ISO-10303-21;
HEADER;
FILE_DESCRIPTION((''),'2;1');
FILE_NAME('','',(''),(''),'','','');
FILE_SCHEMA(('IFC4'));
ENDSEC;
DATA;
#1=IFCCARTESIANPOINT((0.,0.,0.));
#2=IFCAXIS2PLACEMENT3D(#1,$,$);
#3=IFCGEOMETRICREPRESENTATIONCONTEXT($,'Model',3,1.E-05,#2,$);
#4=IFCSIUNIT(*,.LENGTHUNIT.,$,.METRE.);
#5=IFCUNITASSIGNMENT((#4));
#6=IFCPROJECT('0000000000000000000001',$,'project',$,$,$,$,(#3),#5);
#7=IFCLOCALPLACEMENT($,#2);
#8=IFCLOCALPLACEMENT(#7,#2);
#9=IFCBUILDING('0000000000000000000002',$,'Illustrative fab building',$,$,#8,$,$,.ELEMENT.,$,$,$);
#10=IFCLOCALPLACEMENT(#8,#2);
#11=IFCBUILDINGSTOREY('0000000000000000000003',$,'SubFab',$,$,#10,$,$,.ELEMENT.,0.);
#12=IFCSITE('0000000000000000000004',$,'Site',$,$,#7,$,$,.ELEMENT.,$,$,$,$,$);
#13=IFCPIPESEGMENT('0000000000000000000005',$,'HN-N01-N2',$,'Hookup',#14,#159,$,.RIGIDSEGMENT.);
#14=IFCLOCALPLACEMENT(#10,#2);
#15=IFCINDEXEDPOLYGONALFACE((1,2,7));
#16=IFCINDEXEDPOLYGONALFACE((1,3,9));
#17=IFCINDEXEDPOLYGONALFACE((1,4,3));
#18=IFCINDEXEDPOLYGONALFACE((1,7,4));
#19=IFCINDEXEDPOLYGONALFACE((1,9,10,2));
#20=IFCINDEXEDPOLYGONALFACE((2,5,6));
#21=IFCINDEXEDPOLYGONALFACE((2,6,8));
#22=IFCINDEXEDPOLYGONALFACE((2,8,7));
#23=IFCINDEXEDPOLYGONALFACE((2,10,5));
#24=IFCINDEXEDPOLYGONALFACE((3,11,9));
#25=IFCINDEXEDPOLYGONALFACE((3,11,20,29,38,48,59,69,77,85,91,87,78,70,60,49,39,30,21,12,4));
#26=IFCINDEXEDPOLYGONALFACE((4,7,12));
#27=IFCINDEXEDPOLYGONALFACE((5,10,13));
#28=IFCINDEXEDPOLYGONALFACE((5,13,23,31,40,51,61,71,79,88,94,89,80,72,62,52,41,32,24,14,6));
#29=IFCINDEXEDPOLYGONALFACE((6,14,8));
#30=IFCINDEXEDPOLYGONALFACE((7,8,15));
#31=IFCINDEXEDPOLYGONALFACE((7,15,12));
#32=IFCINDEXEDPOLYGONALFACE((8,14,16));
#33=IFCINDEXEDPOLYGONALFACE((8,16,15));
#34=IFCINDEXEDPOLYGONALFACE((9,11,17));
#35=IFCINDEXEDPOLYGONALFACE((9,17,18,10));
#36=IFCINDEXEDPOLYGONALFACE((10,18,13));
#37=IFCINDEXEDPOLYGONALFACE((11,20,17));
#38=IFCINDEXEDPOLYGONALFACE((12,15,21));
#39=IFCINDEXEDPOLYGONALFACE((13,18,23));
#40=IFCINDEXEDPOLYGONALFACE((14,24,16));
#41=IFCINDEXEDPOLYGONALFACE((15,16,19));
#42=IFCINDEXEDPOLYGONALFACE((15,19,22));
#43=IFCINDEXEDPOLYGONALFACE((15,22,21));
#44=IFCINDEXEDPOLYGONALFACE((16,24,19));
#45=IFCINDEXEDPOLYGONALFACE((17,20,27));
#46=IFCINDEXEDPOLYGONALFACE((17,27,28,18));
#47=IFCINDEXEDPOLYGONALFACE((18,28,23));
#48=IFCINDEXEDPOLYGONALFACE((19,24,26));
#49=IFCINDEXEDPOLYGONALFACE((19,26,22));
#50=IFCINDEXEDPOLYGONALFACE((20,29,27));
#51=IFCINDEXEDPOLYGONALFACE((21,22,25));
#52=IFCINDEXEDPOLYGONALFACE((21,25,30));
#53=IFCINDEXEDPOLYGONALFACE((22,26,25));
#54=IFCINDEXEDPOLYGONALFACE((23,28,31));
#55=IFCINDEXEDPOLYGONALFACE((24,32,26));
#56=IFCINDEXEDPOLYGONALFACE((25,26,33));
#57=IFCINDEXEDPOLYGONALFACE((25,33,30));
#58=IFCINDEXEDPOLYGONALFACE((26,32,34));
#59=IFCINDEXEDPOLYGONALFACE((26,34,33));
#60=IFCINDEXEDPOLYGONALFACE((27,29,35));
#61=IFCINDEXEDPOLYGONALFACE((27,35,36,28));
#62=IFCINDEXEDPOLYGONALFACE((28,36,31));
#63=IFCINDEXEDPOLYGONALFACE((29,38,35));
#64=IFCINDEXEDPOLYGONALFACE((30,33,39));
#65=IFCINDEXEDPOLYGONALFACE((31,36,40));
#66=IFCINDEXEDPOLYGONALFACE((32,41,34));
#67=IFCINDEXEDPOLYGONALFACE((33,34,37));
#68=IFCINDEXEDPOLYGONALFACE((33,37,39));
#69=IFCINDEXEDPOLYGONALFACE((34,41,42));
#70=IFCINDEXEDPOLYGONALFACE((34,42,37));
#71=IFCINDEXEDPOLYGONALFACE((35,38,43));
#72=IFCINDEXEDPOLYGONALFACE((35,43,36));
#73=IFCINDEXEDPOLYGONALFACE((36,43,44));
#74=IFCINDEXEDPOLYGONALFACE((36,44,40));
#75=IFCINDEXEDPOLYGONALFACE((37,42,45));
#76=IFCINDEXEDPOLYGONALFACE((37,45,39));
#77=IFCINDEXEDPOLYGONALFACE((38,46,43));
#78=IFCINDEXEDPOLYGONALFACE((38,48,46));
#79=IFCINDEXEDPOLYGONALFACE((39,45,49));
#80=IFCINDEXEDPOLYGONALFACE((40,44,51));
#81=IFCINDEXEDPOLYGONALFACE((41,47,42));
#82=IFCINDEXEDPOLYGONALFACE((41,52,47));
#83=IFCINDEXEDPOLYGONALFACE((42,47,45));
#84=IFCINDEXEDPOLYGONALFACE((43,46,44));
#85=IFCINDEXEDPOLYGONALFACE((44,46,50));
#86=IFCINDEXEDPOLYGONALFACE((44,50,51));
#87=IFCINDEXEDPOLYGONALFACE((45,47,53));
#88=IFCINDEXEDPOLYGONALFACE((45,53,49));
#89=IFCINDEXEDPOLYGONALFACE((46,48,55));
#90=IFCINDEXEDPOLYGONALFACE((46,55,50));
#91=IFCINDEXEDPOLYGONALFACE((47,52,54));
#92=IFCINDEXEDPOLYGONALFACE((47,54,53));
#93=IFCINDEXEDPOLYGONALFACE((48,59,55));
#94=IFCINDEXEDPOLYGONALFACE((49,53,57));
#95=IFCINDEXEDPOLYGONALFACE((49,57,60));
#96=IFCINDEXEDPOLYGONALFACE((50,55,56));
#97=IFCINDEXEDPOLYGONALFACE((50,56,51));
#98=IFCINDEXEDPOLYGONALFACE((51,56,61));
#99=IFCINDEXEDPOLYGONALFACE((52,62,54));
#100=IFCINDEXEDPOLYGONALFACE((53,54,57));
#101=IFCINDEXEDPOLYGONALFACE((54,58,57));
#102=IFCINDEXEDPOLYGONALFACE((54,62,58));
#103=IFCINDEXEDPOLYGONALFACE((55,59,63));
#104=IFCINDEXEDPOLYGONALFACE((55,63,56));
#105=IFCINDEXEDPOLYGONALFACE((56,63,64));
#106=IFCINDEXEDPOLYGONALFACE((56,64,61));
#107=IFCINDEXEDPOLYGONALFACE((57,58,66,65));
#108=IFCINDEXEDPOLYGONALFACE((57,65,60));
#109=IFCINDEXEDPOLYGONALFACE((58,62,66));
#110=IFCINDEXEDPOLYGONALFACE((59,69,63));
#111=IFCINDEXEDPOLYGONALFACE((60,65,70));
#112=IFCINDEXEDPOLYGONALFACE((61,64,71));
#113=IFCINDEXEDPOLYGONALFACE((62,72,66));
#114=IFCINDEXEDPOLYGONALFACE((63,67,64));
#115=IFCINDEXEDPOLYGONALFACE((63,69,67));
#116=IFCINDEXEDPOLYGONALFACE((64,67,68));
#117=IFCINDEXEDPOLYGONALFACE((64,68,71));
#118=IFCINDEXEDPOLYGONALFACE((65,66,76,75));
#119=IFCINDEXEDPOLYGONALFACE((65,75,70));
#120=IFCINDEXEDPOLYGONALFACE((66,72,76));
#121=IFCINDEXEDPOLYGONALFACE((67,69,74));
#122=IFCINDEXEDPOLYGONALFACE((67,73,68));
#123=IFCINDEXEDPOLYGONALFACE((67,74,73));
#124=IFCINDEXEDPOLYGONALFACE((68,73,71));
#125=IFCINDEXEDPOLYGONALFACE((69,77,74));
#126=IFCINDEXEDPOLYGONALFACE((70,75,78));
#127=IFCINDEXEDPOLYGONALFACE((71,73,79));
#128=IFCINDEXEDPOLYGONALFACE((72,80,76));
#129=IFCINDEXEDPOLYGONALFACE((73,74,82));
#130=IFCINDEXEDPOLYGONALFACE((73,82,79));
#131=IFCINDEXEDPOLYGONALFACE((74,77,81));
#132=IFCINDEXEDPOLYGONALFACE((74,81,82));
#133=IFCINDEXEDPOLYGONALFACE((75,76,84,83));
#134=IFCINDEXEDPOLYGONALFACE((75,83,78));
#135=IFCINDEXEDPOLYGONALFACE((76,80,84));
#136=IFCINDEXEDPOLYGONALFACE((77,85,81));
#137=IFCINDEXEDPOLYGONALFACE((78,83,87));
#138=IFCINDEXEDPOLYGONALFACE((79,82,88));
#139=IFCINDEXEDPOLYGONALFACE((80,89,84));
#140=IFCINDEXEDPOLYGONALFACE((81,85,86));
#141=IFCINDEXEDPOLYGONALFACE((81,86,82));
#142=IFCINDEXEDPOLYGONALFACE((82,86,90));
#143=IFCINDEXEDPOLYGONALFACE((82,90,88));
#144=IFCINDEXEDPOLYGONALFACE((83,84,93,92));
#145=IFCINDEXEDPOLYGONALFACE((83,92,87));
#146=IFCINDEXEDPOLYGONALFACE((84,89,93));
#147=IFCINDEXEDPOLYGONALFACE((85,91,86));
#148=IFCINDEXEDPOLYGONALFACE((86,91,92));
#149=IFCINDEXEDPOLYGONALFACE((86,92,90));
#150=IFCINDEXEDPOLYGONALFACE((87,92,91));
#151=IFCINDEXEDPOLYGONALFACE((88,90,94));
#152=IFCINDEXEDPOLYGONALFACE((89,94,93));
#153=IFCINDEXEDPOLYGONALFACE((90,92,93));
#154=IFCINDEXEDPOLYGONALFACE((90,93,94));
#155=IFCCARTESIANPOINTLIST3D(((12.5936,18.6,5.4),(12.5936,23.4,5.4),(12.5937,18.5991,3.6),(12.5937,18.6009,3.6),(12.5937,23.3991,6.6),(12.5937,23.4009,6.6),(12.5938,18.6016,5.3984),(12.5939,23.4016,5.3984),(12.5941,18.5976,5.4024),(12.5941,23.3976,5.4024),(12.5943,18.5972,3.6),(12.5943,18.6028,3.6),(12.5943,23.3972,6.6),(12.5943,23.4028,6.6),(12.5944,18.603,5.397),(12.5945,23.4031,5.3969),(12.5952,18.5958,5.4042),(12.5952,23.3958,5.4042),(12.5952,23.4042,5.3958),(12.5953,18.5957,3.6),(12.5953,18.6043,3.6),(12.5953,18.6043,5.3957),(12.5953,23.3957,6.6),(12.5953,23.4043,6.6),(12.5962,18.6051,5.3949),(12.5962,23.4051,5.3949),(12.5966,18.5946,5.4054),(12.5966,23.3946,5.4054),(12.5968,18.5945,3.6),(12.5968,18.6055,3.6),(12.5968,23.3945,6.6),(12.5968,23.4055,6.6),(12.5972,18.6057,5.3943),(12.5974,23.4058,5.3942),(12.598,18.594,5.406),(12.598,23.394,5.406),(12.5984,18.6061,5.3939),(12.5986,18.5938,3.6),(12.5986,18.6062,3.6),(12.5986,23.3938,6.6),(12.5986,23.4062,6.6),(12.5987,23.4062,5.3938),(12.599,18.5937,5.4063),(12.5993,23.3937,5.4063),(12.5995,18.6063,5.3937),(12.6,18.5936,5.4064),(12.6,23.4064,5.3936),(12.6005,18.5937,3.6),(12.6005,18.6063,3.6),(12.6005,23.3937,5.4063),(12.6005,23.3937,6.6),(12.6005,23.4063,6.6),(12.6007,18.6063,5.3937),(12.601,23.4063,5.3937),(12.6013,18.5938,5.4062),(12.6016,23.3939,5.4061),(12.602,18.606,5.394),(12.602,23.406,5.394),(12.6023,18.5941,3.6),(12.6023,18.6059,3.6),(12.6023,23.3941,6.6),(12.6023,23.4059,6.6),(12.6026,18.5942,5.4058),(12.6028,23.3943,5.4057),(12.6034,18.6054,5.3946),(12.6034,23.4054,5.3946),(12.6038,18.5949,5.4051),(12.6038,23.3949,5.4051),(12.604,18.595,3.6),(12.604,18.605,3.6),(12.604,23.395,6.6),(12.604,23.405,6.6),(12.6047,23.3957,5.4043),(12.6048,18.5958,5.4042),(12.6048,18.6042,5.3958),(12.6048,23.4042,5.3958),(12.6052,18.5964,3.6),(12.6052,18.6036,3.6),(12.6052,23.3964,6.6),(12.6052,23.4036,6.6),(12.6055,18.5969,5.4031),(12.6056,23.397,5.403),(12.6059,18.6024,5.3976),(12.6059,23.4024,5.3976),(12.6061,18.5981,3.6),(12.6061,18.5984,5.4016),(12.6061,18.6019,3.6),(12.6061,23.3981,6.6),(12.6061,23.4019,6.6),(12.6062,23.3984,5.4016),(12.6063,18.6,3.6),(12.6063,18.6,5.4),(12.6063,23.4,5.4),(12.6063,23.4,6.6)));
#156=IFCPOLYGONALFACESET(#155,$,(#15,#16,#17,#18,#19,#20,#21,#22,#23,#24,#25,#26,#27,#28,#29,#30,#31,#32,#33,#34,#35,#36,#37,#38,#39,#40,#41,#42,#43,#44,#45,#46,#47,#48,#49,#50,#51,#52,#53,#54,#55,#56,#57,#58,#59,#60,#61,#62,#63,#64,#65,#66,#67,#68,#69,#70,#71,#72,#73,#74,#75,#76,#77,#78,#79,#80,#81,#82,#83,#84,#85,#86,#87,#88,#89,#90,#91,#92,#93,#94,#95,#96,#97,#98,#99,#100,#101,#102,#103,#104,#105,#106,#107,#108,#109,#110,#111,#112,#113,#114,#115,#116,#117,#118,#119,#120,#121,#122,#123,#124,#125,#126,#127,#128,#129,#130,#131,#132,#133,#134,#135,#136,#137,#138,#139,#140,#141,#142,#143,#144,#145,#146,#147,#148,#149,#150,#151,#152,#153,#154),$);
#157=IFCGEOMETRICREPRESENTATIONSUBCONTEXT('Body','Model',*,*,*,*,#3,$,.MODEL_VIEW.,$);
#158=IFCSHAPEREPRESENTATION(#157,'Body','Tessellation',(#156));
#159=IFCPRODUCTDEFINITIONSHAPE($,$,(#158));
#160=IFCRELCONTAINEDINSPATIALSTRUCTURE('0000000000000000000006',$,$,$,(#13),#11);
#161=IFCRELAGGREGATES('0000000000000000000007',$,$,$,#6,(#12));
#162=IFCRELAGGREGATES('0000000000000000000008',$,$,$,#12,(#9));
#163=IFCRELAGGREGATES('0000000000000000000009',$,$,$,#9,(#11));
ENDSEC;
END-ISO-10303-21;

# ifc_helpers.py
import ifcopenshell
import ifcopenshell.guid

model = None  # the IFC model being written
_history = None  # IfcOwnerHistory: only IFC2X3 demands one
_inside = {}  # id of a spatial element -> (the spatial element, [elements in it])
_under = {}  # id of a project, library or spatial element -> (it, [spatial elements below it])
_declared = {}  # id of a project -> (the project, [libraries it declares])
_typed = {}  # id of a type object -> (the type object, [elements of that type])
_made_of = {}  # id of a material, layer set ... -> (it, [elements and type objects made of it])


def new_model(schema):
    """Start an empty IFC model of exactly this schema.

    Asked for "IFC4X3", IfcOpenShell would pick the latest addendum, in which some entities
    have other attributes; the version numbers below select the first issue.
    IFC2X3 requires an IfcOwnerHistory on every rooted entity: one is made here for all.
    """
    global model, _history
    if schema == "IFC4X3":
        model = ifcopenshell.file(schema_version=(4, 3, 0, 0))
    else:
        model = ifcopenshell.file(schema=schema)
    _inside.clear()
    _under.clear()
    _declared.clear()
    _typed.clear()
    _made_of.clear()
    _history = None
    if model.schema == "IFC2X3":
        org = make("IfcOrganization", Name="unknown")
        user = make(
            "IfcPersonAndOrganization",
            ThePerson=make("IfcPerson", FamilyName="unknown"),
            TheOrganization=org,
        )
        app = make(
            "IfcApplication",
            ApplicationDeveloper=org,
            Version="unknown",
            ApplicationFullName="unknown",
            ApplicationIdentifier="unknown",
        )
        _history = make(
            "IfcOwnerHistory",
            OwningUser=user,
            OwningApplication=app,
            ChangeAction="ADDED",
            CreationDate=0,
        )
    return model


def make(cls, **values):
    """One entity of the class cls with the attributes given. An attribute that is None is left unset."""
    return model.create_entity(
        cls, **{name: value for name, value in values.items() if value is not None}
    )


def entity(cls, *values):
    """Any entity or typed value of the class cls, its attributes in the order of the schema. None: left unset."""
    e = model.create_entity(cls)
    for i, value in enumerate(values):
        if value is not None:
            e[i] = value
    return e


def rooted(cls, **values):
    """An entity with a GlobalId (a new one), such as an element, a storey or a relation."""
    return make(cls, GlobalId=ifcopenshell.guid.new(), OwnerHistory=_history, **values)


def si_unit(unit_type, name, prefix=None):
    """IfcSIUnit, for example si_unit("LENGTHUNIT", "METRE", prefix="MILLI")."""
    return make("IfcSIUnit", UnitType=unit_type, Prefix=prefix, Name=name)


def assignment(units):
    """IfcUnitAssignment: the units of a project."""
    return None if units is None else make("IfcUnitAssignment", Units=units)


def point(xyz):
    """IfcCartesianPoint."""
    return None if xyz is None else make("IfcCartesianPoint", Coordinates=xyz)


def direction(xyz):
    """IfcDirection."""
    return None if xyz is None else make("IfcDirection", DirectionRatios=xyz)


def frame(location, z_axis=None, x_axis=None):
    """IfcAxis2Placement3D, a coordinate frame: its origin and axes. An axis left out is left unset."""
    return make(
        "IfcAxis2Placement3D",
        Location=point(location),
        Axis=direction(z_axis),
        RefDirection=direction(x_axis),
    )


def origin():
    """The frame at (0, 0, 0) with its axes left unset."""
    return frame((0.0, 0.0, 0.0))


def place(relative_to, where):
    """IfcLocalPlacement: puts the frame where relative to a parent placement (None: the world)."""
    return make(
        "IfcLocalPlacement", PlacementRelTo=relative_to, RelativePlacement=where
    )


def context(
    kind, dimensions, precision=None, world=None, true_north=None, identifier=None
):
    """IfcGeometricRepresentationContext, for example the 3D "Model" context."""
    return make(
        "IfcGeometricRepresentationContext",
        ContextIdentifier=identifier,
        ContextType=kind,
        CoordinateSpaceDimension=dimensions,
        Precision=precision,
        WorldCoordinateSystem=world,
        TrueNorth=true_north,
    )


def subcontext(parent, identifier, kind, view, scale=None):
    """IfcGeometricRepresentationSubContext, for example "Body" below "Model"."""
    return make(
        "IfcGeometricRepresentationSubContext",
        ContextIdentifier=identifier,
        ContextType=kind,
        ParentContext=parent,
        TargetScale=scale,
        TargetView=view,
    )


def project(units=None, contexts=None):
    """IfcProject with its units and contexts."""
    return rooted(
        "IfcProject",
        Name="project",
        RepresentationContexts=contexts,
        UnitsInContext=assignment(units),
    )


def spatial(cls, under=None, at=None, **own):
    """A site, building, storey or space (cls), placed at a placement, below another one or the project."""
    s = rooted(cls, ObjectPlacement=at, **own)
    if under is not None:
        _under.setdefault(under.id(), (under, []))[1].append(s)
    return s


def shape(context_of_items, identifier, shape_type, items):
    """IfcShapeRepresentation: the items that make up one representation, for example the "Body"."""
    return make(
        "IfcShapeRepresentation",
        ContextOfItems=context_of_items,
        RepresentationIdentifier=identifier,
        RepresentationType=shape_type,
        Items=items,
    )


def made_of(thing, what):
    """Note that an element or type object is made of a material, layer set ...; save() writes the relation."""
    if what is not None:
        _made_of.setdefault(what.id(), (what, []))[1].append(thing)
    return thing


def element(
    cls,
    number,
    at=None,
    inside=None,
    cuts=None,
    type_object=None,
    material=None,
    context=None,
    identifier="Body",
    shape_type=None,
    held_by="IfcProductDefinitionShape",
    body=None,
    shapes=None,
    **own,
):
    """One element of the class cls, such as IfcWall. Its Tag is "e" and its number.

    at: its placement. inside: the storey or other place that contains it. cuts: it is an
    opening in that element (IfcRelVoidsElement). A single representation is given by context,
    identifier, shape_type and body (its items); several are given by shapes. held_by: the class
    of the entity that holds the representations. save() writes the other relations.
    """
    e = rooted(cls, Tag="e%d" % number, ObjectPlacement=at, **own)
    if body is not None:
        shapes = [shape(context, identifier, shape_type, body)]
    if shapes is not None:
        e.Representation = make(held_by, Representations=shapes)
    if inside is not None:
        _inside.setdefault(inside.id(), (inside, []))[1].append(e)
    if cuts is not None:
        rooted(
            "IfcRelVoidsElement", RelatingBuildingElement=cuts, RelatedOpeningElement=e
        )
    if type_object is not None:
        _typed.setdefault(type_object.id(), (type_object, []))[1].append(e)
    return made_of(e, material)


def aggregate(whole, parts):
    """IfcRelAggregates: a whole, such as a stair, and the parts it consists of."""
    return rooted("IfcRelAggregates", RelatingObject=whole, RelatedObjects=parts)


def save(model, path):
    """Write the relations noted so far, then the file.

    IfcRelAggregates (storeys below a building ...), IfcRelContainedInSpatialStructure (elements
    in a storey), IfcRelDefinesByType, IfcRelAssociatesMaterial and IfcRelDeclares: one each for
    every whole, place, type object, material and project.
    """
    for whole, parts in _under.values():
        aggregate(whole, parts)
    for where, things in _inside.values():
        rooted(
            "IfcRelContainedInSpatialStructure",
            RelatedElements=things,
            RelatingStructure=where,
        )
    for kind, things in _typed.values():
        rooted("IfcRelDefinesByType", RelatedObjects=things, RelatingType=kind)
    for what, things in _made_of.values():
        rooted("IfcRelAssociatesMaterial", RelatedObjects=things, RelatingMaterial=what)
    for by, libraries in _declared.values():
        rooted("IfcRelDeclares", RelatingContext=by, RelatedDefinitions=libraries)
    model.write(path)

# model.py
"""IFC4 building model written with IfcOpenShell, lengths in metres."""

from ifc_helpers import new_model, entity, si_unit, origin, place, context, subcontext, project, spatial, element, save


model = new_model("IFC4")

# Units and contexts
model_context = context("Model", 3, precision=1e-05, world=origin())
body_context = subcontext(model_context, "Body", "Model", "MODEL_VIEW")
ifc_project = project(units=[si_unit("LENGTHUNIT", "METRE")], contexts=[model_context])

# Site, building, storey
site_placement = place(None, origin())
site = spatial("IfcSite", under=ifc_project, at=site_placement, Name="Site", CompositionType="ELEMENT")
building_placement = place(site_placement, origin())
building = spatial("IfcBuilding", under=site, at=building_placement, Name="Illustrative fab building", CompositionType="ELEMENT")
storey_placement = place(building_placement, origin())
storey = spatial("IfcBuildingStorey", under=building, at=storey_placement, Name="SubFab", CompositionType="ELEMENT", Elevation=0.0)

# Pipe segment
pipe_segment_1_placement = place(storey_placement, origin())
element("IfcPipeSegment", 1, at=pipe_segment_1_placement, inside=storey, Name="HN-N01-N2", ObjectType="Hookup", PredefinedType="RIGIDSEGMENT", context=body_context, shape_type="AdvancedSweptSolid", body=[
    entity("IfcSweptDiskSolid", entity("IfcPolyline", [entity("IfcCartesianPoint", [12.6, 18.6, 3.6]), entity("IfcCartesianPoint", [12.6, 18.6, 5.4]), entity("IfcCartesianPoint", [12.6, 23.4, 5.4]), entity("IfcCartesianPoint", [12.6, 23.4, 6.6])]), 0.0063),
])

save(model, "model.ifc")
